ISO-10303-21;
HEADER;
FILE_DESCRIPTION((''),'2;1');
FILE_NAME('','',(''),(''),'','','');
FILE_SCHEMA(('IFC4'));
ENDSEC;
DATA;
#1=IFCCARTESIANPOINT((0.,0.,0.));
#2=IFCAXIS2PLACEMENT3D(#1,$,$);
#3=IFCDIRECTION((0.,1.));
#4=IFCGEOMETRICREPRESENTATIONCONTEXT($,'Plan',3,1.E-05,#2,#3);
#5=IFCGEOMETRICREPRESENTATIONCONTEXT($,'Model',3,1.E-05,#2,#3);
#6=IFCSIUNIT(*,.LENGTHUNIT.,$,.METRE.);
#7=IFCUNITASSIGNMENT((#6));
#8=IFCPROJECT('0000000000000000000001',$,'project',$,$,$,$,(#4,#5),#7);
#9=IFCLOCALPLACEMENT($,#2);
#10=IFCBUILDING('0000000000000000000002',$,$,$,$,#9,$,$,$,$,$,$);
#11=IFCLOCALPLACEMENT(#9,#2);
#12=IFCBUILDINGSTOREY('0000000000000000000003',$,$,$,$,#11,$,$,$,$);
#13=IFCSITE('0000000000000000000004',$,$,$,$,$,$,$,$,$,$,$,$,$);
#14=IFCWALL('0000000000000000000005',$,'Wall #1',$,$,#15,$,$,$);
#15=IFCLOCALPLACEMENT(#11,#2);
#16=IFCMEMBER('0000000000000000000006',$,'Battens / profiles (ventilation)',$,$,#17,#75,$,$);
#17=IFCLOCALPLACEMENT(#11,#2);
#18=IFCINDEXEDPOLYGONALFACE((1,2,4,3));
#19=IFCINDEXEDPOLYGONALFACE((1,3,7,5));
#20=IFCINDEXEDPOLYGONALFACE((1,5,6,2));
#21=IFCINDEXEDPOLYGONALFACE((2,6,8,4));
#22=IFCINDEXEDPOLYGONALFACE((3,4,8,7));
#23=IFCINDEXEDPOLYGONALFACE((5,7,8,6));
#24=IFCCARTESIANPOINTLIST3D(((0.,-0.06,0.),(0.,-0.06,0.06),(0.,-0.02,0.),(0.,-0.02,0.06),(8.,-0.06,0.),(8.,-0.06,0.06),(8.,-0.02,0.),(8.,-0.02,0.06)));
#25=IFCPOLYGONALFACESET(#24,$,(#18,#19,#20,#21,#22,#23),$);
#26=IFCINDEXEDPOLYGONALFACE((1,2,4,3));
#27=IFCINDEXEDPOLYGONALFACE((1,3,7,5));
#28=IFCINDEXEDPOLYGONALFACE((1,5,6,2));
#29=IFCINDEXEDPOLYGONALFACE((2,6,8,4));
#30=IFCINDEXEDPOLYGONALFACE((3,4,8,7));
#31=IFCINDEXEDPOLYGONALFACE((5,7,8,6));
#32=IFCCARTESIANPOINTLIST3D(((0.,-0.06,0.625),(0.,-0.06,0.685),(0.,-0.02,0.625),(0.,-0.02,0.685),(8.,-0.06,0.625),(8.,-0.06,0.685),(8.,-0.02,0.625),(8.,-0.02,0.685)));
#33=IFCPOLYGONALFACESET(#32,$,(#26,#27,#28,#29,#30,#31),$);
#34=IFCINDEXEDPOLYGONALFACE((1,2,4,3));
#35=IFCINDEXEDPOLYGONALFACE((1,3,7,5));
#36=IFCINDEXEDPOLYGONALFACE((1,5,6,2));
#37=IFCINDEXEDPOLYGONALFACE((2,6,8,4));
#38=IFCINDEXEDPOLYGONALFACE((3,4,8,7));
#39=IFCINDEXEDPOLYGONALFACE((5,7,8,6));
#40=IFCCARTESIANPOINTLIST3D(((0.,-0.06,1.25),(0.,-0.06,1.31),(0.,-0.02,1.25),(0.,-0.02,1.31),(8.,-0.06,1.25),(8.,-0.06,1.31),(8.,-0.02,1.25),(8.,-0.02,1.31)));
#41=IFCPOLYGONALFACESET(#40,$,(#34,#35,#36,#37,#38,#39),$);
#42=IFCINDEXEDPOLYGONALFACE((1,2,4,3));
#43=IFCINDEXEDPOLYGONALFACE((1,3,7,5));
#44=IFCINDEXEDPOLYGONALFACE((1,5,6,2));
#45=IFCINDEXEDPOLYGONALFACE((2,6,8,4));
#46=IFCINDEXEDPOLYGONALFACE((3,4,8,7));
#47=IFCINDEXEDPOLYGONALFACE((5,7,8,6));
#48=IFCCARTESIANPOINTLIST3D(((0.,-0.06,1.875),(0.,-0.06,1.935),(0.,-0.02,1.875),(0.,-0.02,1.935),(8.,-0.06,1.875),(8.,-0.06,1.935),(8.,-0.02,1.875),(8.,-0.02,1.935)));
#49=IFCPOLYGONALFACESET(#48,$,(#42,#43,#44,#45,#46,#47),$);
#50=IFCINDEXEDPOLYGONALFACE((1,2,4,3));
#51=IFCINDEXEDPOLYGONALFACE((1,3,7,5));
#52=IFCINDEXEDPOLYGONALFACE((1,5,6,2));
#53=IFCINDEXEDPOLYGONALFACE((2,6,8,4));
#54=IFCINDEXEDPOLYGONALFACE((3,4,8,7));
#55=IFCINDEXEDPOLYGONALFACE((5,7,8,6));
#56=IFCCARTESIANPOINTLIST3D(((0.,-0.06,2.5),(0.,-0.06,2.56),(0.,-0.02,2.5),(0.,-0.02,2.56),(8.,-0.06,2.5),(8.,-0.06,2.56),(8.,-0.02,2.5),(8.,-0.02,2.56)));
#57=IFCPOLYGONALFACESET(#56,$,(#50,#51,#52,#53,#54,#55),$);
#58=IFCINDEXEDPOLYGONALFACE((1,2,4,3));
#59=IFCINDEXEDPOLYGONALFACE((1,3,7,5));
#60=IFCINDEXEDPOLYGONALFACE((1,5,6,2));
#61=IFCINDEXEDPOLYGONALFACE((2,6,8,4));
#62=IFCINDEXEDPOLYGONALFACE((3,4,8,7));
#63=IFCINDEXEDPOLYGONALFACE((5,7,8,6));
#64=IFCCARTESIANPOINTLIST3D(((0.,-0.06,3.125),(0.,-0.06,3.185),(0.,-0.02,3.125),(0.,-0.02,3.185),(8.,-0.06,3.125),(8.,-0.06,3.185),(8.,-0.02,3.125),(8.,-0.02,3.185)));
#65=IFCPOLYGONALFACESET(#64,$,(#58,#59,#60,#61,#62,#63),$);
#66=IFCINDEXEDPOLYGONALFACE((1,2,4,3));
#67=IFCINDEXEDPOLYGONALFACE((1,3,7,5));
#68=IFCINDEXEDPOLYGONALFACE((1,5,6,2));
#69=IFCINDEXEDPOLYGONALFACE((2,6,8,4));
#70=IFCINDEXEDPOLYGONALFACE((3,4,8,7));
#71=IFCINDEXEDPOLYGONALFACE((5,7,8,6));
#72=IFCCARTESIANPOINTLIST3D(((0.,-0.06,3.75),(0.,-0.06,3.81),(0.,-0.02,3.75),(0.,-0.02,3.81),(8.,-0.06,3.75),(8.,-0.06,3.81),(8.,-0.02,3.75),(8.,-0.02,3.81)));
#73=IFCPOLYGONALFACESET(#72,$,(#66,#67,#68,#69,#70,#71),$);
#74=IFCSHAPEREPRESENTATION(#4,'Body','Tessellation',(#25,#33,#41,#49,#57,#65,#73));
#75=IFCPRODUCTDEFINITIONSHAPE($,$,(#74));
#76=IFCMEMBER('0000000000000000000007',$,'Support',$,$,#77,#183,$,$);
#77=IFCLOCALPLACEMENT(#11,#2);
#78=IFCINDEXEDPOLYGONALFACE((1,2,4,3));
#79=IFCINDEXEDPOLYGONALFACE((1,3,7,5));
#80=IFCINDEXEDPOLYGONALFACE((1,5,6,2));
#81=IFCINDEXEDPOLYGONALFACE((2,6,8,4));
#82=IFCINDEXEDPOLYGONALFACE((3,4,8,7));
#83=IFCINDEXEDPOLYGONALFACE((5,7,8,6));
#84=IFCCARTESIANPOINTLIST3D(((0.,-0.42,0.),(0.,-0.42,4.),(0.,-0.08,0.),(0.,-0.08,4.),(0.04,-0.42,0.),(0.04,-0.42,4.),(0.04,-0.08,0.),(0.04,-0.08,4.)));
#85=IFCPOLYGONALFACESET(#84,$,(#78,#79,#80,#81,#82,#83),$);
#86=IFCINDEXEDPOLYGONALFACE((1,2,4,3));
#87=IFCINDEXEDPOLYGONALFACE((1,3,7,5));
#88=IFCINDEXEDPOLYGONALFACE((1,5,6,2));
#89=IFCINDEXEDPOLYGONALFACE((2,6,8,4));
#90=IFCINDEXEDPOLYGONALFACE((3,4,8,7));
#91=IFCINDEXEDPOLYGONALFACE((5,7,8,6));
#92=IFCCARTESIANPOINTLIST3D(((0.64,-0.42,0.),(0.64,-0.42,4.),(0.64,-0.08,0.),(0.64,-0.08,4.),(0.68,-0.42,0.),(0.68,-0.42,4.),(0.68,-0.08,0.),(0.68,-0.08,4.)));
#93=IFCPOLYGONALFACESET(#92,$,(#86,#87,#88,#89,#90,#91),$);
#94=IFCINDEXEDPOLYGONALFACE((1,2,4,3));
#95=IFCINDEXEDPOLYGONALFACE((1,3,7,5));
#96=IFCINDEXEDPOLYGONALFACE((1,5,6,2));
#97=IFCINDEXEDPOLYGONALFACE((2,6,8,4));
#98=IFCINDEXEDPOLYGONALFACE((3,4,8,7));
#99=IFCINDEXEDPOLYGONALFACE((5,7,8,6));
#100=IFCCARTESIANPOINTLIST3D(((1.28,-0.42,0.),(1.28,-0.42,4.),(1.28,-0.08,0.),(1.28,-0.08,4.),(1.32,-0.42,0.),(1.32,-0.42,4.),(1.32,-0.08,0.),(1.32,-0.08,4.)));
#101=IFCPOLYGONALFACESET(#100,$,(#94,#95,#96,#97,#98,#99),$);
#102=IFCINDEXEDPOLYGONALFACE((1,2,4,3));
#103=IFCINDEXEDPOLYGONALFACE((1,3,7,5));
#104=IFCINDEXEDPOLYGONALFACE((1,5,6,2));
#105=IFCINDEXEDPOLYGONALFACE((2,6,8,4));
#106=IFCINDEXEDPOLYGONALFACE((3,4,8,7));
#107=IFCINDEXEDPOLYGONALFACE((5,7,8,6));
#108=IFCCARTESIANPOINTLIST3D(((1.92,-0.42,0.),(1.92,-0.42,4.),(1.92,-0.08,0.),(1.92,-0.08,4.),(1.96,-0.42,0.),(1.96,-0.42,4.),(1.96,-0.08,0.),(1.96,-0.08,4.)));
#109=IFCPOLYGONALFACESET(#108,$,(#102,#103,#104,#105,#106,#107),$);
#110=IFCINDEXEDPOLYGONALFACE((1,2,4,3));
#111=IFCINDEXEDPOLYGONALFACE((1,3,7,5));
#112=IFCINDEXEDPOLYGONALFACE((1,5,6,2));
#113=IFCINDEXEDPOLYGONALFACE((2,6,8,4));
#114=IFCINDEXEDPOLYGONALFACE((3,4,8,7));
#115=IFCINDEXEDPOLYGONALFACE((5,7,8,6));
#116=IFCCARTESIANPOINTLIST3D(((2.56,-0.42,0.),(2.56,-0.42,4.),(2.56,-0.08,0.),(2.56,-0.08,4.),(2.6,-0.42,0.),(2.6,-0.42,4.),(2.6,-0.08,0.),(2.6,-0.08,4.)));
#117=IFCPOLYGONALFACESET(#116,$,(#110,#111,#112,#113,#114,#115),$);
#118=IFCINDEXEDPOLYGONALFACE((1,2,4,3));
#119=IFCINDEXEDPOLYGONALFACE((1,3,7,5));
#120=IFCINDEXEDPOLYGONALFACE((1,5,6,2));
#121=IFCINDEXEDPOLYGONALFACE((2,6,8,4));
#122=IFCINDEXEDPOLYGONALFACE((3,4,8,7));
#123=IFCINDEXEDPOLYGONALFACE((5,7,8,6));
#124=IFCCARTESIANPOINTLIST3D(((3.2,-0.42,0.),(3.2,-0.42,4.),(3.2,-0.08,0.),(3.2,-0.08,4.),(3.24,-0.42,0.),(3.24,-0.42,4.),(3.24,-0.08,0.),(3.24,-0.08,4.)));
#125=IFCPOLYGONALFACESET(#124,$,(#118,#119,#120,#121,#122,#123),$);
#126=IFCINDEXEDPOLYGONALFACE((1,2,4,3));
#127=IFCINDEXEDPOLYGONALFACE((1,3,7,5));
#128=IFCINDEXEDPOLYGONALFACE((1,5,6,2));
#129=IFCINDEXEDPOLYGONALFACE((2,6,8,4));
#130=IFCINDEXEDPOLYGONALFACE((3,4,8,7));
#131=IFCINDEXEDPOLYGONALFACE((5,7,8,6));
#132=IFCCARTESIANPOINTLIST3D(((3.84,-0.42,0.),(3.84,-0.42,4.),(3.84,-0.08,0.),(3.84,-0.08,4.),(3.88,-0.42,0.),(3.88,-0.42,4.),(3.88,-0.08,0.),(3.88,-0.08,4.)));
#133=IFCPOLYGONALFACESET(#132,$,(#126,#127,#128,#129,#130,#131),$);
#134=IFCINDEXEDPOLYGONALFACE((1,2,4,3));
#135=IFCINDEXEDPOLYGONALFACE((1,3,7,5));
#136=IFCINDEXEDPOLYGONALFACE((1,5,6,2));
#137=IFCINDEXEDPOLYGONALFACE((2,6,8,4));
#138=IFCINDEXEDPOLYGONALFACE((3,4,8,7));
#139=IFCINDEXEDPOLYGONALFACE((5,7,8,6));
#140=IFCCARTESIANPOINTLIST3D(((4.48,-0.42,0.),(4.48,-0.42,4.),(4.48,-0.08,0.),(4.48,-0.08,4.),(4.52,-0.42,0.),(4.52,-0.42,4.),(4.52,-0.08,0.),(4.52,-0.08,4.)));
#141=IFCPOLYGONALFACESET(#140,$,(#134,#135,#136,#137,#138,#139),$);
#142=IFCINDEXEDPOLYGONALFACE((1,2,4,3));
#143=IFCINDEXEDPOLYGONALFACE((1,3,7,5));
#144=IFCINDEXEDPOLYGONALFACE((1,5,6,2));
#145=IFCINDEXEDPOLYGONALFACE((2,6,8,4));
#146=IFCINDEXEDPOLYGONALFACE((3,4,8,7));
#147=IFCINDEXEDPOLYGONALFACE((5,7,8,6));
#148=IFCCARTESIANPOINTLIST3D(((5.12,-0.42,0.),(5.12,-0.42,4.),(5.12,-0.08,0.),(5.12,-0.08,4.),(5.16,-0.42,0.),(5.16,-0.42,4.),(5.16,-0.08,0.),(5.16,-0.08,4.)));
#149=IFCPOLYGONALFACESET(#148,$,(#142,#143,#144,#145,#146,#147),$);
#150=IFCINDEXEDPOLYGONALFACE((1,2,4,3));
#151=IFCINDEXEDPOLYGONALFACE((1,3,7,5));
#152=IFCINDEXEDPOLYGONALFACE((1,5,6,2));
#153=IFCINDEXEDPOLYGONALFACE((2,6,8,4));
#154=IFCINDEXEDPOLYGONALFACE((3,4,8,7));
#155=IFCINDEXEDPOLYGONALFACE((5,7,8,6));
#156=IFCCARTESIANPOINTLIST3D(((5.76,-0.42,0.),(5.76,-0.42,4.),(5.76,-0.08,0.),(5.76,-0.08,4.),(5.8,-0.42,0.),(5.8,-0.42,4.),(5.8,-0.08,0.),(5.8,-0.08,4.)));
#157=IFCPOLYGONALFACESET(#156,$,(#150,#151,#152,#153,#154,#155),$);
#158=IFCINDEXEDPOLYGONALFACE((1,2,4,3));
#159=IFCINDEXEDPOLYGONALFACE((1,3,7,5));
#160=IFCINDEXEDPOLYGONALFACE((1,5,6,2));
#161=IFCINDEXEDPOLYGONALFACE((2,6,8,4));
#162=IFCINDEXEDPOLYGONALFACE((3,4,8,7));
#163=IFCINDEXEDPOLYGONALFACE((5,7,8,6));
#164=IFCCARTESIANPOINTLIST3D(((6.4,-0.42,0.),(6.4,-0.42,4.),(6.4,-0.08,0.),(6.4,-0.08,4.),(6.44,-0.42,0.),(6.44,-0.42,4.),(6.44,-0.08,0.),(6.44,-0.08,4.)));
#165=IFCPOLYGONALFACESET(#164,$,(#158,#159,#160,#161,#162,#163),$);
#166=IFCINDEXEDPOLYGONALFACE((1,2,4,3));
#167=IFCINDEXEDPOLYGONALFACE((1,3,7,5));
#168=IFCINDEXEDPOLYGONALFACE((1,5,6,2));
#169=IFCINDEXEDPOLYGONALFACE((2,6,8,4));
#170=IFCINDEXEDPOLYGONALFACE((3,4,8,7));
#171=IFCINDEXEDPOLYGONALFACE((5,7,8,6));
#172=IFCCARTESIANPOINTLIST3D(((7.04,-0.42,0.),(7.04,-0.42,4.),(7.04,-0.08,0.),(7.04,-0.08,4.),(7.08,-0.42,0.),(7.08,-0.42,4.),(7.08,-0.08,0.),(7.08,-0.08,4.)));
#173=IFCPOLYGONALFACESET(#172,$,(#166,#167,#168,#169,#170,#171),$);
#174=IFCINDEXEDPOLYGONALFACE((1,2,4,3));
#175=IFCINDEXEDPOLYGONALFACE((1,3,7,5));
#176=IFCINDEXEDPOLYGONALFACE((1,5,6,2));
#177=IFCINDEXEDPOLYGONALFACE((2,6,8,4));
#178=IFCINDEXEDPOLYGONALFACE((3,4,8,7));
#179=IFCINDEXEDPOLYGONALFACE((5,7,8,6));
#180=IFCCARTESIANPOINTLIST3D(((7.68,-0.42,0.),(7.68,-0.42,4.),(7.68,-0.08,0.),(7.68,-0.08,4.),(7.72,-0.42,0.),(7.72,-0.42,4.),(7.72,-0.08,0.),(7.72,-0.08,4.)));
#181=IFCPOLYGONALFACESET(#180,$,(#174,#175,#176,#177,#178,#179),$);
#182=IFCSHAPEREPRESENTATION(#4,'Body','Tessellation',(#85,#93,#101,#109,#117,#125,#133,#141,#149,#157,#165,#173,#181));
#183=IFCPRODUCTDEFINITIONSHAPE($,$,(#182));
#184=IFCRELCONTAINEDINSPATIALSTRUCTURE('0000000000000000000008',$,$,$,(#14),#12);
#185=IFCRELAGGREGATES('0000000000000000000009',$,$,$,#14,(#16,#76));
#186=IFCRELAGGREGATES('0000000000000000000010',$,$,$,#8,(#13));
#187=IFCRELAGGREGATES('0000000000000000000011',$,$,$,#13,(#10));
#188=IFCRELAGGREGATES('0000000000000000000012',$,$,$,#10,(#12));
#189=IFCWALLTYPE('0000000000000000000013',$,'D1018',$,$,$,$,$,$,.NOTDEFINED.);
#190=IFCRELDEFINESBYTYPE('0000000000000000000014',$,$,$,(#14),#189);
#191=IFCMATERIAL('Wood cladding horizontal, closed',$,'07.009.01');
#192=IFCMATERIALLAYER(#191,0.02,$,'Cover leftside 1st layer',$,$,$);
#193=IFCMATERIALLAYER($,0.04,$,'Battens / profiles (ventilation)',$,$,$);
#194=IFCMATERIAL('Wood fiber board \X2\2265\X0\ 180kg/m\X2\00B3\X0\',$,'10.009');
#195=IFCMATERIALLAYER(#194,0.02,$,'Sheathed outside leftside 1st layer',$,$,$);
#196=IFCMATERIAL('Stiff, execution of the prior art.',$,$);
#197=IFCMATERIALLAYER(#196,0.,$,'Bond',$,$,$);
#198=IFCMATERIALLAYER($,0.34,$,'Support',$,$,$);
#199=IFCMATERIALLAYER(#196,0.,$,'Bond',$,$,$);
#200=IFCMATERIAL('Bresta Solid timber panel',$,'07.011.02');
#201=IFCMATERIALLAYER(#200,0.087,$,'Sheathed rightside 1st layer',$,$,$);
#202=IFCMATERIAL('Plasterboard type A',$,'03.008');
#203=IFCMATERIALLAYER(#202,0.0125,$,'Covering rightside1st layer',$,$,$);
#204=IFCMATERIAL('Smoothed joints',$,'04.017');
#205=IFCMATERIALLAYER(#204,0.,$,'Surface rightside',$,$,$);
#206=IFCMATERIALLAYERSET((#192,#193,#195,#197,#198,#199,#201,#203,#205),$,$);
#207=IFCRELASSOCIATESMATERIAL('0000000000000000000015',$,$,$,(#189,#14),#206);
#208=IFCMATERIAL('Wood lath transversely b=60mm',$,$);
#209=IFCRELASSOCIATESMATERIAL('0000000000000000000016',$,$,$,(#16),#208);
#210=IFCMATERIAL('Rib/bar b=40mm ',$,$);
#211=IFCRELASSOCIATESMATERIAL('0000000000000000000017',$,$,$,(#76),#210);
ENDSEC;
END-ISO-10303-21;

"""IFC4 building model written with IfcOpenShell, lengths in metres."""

from ifc_helpers import new_model, si_unit, direction, frame, frame_2d, origin, place, context, project, spatial, rectangle, extrude, material, layer, layer_set, type_object, element, aggregate, save


model = new_model("IFC4")

# Units and contexts
plan_context = context("Plan", 3, precision=1e-05, world=origin(), true_north=direction((0.0, 1.0)))
model_context = context("Model", 3, precision=1e-05, world=origin(), true_north=direction((0.0, 1.0)))
ifc_project = project(units=[si_unit("LENGTHUNIT", "METRE")], contexts=[plan_context, model_context])

# Site, building, storey
site = spatial("IfcSite", under=ifc_project)
building_placement = place(None, origin())
building = spatial("IfcBuilding", under=site, at=building_placement)
storey_placement = place(building_placement, origin())
storey = spatial("IfcBuildingStorey", under=building, at=storey_placement)

# Wall, members
ifc_material_1 = material(Name="Wood cladding horizontal, closed", Category="07.009.01")
ifc_layer_1 = layer(ifc_material_1, 0.02, Name="Cover leftside 1st layer")
ifc_layer_2 = layer(None, 0.04, Name="Battens / profiles (ventilation)")
ifc_material_2 = material(Name="Wood fiber board ≥ 180kg/m³", Category="10.009")
ifc_layer_3 = layer(ifc_material_2, 0.02, Name="Sheathed outside leftside 1st layer")
ifc_material_3 = material(Name="Stiff, execution of the prior art.")
ifc_layer_4 = layer(ifc_material_3, 0.0, Name="Bond")
ifc_layer_5 = layer(None, 0.34, Name="Support")
ifc_layer_6 = layer(ifc_material_3, 0.0, Name="Bond")
ifc_material_4 = material(Name="Bresta Solid timber panel", Category="07.011.02")
ifc_layer_7 = layer(ifc_material_4, 0.087, Name="Sheathed rightside 1st layer")
ifc_material_5 = material(Name="Plasterboard type A", Category="03.008")
ifc_layer_8 = layer(ifc_material_5, 0.0125, Name="Covering rightside1st layer")
ifc_material_6 = material(Name="Smoothed joints", Category="04.017")
ifc_layer_9 = layer(ifc_material_6, 0.0, Name="Surface rightside")
ifc_layer_set = layer_set([ifc_layer_1, ifc_layer_2, ifc_layer_3, ifc_layer_4, ifc_layer_5, ifc_layer_6, ifc_layer_7, ifc_layer_8, ifc_layer_9])
wall_type = type_object("IfcWallType", Name="D1018", PredefinedType="NOTDEFINED", material=ifc_layer_set)
wall_placement = place(None, frame((0.0, 0.0, 0.0), z_axis=(0.0, -1.0, 0.0), x_axis=(1.0, 0.0, 0.0)))
wall = element("IfcWall", 1, at=wall_placement, inside=storey, type_object=wall_type, material=ifc_layer_set, Name="Wall #1")
ifc_material_7 = material(Name="Wood lath transversely b=60mm")
member_1_placement = place(wall_placement, origin())
member_1 = element("IfcMember", 2, at=member_1_placement, material=ifc_material_7, Name="Battens / profiles (ventilation)", context=plan_context, shape_type="SweptSolid", body=[
    extrude(rectangle(XDim=0.06, YDim=0.04, at=frame_2d((0.03, 0.02), x_axis=(1.0, 0.0))), frame((0.0, 0.0, 0.02), z_axis=(1.0, 0.0, 0.0), x_axis=(0.0, 1.0, 0.0)), (0.0, 0.0, 1.0), 8.0),
    extrude(rectangle(XDim=0.06, YDim=0.04, at=frame_2d((0.03, 0.02), x_axis=(1.0, 0.0))), frame((0.0, 0.625, 0.02), z_axis=(1.0, 0.0, 0.0), x_axis=(0.0, 1.0, 0.0)), (0.0, 0.0, 1.0), 8.0),
    extrude(rectangle(XDim=0.06, YDim=0.04, at=frame_2d((0.03, 0.02), x_axis=(1.0, 0.0))), frame((0.0, 1.25, 0.02), z_axis=(1.0, 0.0, 0.0), x_axis=(0.0, 1.0, 0.0)), (0.0, 0.0, 1.0), 8.0),
    extrude(rectangle(XDim=0.06, YDim=0.04, at=frame_2d((0.03, 0.02), x_axis=(1.0, 0.0))), frame((0.0, 1.875, 0.02), z_axis=(1.0, 0.0, 0.0), x_axis=(0.0, 1.0, 0.0)), (0.0, 0.0, 1.0), 8.0),
    extrude(rectangle(XDim=0.06, YDim=0.04, at=frame_2d((0.03, 0.02), x_axis=(1.0, 0.0))), frame((0.0, 2.5, 0.02), z_axis=(1.0, 0.0, 0.0), x_axis=(0.0, 1.0, 0.0)), (0.0, 0.0, 1.0), 8.0),
    extrude(rectangle(XDim=0.06, YDim=0.04, at=frame_2d((0.03, 0.02), x_axis=(1.0, 0.0))), frame((0.0, 3.125, 0.02), z_axis=(1.0, 0.0, 0.0), x_axis=(0.0, 1.0, 0.0)), (0.0, 0.0, 1.0), 8.0),
    extrude(rectangle(XDim=0.06, YDim=0.04, at=frame_2d((0.03, 0.02), x_axis=(1.0, 0.0))), frame((0.0, 3.75, 0.02), z_axis=(1.0, 0.0, 0.0), x_axis=(0.0, 1.0, 0.0)), (0.0, 0.0, 1.0), 8.0),
])
ifc_material_8 = material(Name="Rib/bar b=40mm ")
member_2_placement = place(wall_placement, origin())
member_2 = element("IfcMember", 3, at=member_2_placement, material=ifc_material_8, Name="Support", context=plan_context, shape_type="SweptSolid", body=[
    extrude(rectangle(XDim=0.04, YDim=0.34, at=frame_2d((0.02, 0.17), x_axis=(1.0, 0.0))), frame((0.0, 4.0, 0.08), z_axis=(0.0, -1.0, 0.0), x_axis=(1.0, 0.0, 0.0)), (0.0, 0.0, 1.0), 4.0),
    extrude(rectangle(XDim=0.04, YDim=0.34, at=frame_2d((0.02, 0.17), x_axis=(1.0, 0.0))), frame((0.64, 4.0, 0.08), z_axis=(0.0, -1.0, 0.0), x_axis=(1.0, 0.0, 0.0)), (0.0, 0.0, 1.0), 4.0),
    extrude(rectangle(XDim=0.04, YDim=0.34, at=frame_2d((0.02, 0.17), x_axis=(1.0, 0.0))), frame((1.28, 4.0, 0.08), z_axis=(0.0, -1.0, 0.0), x_axis=(1.0, 0.0, 0.0)), (0.0, 0.0, 1.0), 4.0),
    extrude(rectangle(XDim=0.04, YDim=0.34, at=frame_2d((0.02, 0.17), x_axis=(1.0, 0.0))), frame((1.92, 4.0, 0.08), z_axis=(0.0, -1.0, 0.0), x_axis=(1.0, 0.0, 0.0)), (0.0, 0.0, 1.0), 4.0),
    extrude(rectangle(XDim=0.04, YDim=0.34, at=frame_2d((0.02, 0.17), x_axis=(1.0, 0.0))), frame((2.56, 4.0, 0.08), z_axis=(0.0, -1.0, 0.0), x_axis=(1.0, 0.0, 0.0)), (0.0, 0.0, 1.0), 4.0),
    extrude(rectangle(XDim=0.04, YDim=0.34, at=frame_2d((0.02, 0.17), x_axis=(1.0, 0.0))), frame((3.2, 4.0, 0.08), z_axis=(0.0, -1.0, 0.0), x_axis=(1.0, 0.0, 0.0)), (0.0, 0.0, 1.0), 4.0),
    extrude(rectangle(XDim=0.04, YDim=0.34, at=frame_2d((0.02, 0.17), x_axis=(1.0, 0.0))), frame((3.84, 4.0, 0.08), z_axis=(0.0, -1.0, 0.0), x_axis=(1.0, 0.0, 0.0)), (0.0, 0.0, 1.0), 4.0),
    extrude(rectangle(XDim=0.04, YDim=0.34, at=frame_2d((0.02, 0.17), x_axis=(1.0, 0.0))), frame((4.48, 4.0, 0.08), z_axis=(0.0, -1.0, 0.0), x_axis=(1.0, 0.0, 0.0)), (0.0, 0.0, 1.0), 4.0),
    extrude(rectangle(XDim=0.04, YDim=0.34, at=frame_2d((0.02, 0.17), x_axis=(1.0, 0.0))), frame((5.12, 4.0, 0.08), z_axis=(0.0, -1.0, 0.0), x_axis=(1.0, 0.0, 0.0)), (0.0, 0.0, 1.0), 4.0),
    extrude(rectangle(XDim=0.04, YDim=0.34, at=frame_2d((0.02, 0.17), x_axis=(1.0, 0.0))), frame((5.76, 4.0, 0.08), z_axis=(0.0, -1.0, 0.0), x_axis=(1.0, 0.0, 0.0)), (0.0, 0.0, 1.0), 4.0),
    extrude(rectangle(XDim=0.04, YDim=0.34, at=frame_2d((0.02, 0.17), x_axis=(1.0, 0.0))), frame((6.4, 4.0, 0.08), z_axis=(0.0, -1.0, 0.0), x_axis=(1.0, 0.0, 0.0)), (0.0, 0.0, 1.0), 4.0),
    extrude(rectangle(XDim=0.04, YDim=0.34, at=frame_2d((0.02, 0.17), x_axis=(1.0, 0.0))), frame((7.04, 4.0, 0.08), z_axis=(0.0, -1.0, 0.0), x_axis=(1.0, 0.0, 0.0)), (0.0, 0.0, 1.0), 4.0),
    extrude(rectangle(XDim=0.04, YDim=0.34, at=frame_2d((0.02, 0.17), x_axis=(1.0, 0.0))), frame((7.68, 4.0, 0.08), z_axis=(0.0, -1.0, 0.0), x_axis=(1.0, 0.0, 0.0)), (0.0, 0.0, 1.0), 4.0),
])
aggregate(wall, [member_1, member_2])

save(model, "model.ifc")
